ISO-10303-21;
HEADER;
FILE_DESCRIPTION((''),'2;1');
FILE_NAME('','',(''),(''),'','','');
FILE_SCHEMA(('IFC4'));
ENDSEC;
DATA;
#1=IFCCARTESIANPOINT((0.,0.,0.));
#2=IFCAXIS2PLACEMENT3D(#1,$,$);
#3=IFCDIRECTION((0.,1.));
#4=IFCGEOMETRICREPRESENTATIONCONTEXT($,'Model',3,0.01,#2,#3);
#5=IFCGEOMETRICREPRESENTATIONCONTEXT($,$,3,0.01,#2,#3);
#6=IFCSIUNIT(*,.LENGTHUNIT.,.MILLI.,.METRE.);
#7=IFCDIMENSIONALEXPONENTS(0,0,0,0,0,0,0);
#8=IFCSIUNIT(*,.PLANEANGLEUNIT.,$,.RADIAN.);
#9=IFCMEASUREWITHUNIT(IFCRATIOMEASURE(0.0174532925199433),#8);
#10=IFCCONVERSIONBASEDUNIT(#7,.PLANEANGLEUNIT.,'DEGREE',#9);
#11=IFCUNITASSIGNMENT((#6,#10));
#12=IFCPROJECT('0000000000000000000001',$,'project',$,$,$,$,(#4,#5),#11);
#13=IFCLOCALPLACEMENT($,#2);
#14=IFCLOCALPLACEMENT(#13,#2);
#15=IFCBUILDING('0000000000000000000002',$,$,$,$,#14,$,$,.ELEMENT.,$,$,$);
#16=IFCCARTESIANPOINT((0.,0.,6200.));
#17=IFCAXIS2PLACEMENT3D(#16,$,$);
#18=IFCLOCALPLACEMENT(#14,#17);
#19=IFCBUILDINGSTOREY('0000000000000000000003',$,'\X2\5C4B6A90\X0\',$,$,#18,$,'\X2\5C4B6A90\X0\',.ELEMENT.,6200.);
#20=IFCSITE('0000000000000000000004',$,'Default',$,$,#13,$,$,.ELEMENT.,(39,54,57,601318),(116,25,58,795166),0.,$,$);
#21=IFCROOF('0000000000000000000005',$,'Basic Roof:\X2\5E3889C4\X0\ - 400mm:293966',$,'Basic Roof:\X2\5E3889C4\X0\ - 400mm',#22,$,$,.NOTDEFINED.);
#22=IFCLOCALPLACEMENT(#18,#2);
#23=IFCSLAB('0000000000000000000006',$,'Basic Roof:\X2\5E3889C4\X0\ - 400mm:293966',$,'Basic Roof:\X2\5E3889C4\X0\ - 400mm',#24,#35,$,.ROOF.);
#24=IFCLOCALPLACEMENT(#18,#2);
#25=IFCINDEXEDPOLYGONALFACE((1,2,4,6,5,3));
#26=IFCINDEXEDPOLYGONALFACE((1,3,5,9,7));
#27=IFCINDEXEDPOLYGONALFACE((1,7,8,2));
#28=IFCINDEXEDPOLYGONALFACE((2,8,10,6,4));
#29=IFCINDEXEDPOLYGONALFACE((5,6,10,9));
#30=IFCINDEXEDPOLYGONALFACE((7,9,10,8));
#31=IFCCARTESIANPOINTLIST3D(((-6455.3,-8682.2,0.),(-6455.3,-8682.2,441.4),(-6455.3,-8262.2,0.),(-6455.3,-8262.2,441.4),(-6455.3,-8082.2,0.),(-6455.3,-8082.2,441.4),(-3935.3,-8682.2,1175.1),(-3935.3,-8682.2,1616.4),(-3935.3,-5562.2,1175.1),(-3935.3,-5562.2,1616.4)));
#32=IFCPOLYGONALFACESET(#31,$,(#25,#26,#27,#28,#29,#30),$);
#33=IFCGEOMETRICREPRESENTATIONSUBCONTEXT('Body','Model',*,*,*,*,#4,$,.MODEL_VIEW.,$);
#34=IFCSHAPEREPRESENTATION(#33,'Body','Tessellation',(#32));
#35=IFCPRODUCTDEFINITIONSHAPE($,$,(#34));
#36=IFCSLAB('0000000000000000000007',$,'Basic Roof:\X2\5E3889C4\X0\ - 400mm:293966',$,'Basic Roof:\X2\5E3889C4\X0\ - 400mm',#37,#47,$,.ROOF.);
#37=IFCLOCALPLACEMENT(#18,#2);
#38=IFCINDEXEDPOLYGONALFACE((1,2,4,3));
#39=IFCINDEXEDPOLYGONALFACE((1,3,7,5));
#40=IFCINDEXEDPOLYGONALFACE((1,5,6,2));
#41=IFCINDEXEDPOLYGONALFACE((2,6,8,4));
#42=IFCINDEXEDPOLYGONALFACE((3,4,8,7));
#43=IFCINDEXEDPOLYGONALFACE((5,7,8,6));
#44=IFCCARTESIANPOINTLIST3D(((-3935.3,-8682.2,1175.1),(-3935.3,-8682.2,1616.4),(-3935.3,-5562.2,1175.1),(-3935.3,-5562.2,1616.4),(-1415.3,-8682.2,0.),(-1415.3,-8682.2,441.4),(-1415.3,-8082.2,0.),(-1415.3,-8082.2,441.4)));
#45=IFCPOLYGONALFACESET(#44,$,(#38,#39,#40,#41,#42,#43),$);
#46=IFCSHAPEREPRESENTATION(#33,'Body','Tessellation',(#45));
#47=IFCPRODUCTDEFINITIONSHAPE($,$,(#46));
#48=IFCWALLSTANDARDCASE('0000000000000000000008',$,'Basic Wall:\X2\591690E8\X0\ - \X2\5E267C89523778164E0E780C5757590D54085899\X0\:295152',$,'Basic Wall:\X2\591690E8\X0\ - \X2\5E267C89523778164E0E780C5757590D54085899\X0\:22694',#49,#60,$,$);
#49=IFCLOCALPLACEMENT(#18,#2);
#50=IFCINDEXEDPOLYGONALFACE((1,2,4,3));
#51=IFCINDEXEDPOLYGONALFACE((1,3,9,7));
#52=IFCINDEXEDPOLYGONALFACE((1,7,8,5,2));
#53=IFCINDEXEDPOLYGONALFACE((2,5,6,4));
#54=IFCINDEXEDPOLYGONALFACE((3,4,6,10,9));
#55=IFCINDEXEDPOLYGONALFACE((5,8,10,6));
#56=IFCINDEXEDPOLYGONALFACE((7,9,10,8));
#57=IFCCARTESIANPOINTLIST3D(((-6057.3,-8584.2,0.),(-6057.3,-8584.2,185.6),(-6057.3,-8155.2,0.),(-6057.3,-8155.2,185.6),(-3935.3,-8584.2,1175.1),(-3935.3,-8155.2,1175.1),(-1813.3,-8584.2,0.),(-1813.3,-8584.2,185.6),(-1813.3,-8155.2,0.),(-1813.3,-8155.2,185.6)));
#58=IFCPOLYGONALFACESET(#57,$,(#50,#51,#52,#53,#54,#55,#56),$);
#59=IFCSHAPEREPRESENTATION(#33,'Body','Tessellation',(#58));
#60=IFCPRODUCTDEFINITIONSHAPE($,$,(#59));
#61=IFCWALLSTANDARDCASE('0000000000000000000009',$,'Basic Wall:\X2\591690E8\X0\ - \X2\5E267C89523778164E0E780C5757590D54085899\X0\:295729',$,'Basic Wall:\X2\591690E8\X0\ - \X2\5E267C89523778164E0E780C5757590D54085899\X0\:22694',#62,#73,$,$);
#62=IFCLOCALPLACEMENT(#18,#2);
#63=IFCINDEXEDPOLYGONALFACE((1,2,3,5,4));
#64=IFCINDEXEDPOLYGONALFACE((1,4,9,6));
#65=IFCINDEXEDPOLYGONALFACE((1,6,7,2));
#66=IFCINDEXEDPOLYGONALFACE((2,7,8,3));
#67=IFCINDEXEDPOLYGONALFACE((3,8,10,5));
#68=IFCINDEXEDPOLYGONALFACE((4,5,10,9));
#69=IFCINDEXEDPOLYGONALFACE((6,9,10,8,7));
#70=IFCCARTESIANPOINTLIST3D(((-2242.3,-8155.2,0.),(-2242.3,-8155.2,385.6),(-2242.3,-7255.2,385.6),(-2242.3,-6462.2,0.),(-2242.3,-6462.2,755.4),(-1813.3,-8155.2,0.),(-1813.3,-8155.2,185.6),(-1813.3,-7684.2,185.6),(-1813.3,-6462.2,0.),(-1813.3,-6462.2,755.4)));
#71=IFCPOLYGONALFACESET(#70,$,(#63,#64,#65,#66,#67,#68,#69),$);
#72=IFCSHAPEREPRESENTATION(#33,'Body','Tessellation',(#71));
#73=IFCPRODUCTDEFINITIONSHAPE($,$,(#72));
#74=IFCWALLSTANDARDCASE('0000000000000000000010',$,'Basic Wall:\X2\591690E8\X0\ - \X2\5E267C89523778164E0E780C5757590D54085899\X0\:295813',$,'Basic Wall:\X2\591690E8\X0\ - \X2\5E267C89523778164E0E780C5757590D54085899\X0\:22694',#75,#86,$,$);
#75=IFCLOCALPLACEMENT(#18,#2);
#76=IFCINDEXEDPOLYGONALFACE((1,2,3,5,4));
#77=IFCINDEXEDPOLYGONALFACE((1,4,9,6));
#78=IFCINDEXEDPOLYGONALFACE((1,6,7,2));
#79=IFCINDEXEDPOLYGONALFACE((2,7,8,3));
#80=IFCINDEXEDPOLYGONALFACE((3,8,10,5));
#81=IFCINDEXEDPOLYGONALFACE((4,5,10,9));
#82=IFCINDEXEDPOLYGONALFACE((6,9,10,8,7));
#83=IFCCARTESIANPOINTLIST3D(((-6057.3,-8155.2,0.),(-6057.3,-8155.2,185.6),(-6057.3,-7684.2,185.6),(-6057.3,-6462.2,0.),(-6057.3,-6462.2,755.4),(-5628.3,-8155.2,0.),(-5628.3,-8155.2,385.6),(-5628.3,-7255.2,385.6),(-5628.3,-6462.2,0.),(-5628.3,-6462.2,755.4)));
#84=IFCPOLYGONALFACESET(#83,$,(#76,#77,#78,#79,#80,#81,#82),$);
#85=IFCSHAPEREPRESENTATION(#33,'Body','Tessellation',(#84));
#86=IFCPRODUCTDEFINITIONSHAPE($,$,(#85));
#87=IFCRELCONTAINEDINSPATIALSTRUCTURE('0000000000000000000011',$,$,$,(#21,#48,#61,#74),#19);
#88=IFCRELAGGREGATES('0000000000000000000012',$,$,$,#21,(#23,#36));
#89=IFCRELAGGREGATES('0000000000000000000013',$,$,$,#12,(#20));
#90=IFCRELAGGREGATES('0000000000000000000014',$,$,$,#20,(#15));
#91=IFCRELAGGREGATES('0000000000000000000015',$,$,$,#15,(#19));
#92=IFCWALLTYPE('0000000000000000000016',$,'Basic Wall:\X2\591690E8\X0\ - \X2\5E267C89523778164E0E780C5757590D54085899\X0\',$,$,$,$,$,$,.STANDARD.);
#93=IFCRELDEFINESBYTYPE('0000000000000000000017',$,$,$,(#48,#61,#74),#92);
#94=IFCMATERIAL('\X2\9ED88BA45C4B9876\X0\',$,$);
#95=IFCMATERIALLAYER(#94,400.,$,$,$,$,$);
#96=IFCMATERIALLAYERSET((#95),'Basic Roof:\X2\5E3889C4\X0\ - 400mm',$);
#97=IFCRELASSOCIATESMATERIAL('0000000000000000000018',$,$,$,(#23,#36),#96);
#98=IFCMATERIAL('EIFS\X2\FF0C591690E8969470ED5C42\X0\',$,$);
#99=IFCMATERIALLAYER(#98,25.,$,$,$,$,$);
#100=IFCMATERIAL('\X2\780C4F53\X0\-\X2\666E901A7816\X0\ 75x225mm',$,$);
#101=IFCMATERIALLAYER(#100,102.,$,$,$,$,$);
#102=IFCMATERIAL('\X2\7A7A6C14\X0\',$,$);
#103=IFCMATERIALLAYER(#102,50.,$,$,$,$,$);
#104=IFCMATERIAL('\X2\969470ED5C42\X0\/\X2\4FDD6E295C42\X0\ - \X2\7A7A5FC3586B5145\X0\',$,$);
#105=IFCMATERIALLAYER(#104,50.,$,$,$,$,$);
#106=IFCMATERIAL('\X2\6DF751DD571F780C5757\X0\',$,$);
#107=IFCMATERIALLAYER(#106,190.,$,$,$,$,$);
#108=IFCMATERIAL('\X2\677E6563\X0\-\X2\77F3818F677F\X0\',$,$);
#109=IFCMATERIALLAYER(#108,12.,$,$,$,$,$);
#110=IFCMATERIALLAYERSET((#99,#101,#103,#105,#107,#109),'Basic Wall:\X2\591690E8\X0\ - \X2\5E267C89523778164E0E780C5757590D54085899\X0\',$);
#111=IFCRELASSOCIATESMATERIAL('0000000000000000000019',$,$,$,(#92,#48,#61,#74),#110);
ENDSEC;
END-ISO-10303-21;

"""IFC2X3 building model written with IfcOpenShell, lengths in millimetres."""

from ifc_helpers import new_model, entity, si_unit, converted_unit, direction, frame, frame_2d, origin, place, context, subcontext, project, spatial, polyline, rectangle, outline, extrude, clip, bounded_halfspace, material, layer, layer_set, layer_usage, type_object, element, aggregate, save


model = new_model("IFC2X3")

# Units and contexts
model_context = context("Model", 3, precision=0.01, world=origin(), true_north=direction((0.0, 1.0)))
context_of_model = context(None, 3, precision=0.01, world=origin(), true_north=direction((0.0, 1.0)))
body_context = subcontext(model_context, "Body", "Model", "MODEL_VIEW")
ifc_project = project(units=[si_unit("LENGTHUNIT", "METRE", prefix="MILLI"), converted_unit("PLANEANGLEUNIT", "DEGREE", entity("IfcRatioMeasure", 0.0174532925199433), si_unit("PLANEANGLEUNIT", "RADIAN"), dimensions=[0, 0, 0, 0, 0, 0, 0])], contexts=[model_context, context_of_model])

# Site, building, storey
site_placement = place(None, origin())
site = spatial("IfcSite", under=ifc_project, at=site_placement, Name="Default", CompositionType="ELEMENT", RefLatitude=(39, 54, 57, 601318), RefLongitude=(116, 25, 58, 795166), RefElevation=0.0)
building_placement = place(site_placement, origin())
building = spatial("IfcBuilding", under=site, at=building_placement, CompositionType="ELEMENT")
storey_placement = place(building_placement, frame((0.0, 0.0, 6200.0)))
storey = spatial("IfcBuildingStorey", under=building, at=storey_placement, Name="屋檐", LongName="屋檐", CompositionType="ELEMENT", Elevation=6200.0)

# Roof, slabs
roof_placement = place(storey_placement, frame((-9755.3, -8682.2, 0.0)))
roof = element("IfcRoof", 1, at=roof_placement, inside=storey, Name="Basic Roof:常规 - 400mm:293966", ObjectType="Basic Roof:常规 - 400mm", ShapeType="NOTDEFINED")
ifc_material_1 = material(Name="默认屋顶")
ifc_layer_1 = layer(ifc_material_1, 400.0)
ifc_layer_set_1 = layer_set([ifc_layer_1], Name="Basic Roof:常规 - 400mm")
slab_1_placement = place(roof_placement, origin())
slab_1 = element("IfcSlab", 2, at=slab_1_placement, material=ifc_layer_set_1, Name="Basic Roof:常规 - 400mm:293966", ObjectType="Basic Roof:常规 - 400mm", PredefinedType="ROOF", context=body_context, shape_type="SweptSolid", body=[
    extrude(outline(polyline([(-1390.3, -1560.0), (1390.3, -1560.0), (1390.3, 1560.0), (-1390.3, -960.0), (-1390.3, -1140.0), (-1390.3, -1560.0)])), frame((4560.0, 1560.0, 587.5), z_axis=(-0.422618, 0.0, 0.906308), x_axis=(0.906308, 0.0, 0.422618)), (0.422618, 0.0, 0.906308), 441.4),
])
slab_2_placement = place(roof_placement, origin())
slab_2 = element("IfcSlab", 3, at=slab_2_placement, material=ifc_layer_set_1, Name="Basic Roof:常规 - 400mm:293966", ObjectType="Basic Roof:常规 - 400mm", PredefinedType="ROOF", context=body_context, shape_type="SweptSolid", body=[
    extrude(outline(polyline([(1390.3, -960.0), (-1390.3, 1560.0), (-1390.3, -1560.0), (1390.3, -1560.0), (1390.3, -960.0)])), frame((7080.0, 1560.0, 587.5), z_axis=(0.422618, 0.0, 0.906308), x_axis=(0.906308, 0.0, -0.422618)), (-0.422618, 0.0, 0.906308), 441.4),
])
aggregate(roof, [slab_1, slab_2])

# Walls
ifc_material_2 = material(Name="EIFS，外部隔热层")
ifc_layer_2 = layer(ifc_material_2, 25.0)
ifc_material_3 = material(Name="砌体-普通砖 75x225mm")
ifc_layer_3 = layer(ifc_material_3, 102.0)
ifc_material_4 = material(Name="空气")
ifc_layer_4 = layer(ifc_material_4, 50.0)
ifc_material_5 = material(Name="隔热层/保温层 - 空心填充")
ifc_layer_5 = layer(ifc_material_5, 50.0)
ifc_material_6 = material(Name="混凝土砌块")
ifc_layer_6 = layer(ifc_material_6, 190.0)
ifc_material_7 = material(Name="松散-石膏板")
ifc_layer_7 = layer(ifc_material_7, 12.0)
ifc_layer_set_2 = layer_set([ifc_layer_2, ifc_layer_3, ifc_layer_4, ifc_layer_5, ifc_layer_6, ifc_layer_7], Name="Basic Wall:外部 - 带粉刷砖与砌块复合墙")
ifc_layer_usage_1 = layer_usage(ifc_layer_set_2, "AXIS2", "NEGATIVE", 214.5)
wall_type = type_object("IfcWallType", Name="Basic Wall:外部 - 带粉刷砖与砌块复合墙", PredefinedType="STANDARD", material=ifc_layer_set_2)
wall_1_placement = place(storey_placement, frame((-1813.3, -8369.7, 0.0), z_axis=(0.0, 0.0, 1.0), x_axis=(-1.0, 0.0, 0.0)))
element("IfcWallStandardCase", 4, at=wall_1_placement, inside=storey, type_object=wall_type, material=ifc_layer_usage_1, Name="Basic Wall:外部 - 带粉刷砖与砌块复合墙:295152", ObjectType="Basic Wall:外部 - 带粉刷砖与砌块复合墙:22694", context=body_context, shape_type="Clipping", body=[
    clip(clip(extrude(rectangle(XDim=4244.0, YDim=429.0, at=frame_2d((2122.0, 0.0), x_axis=(-1.0, 0.0))), origin(), (0.0, 0.0, 1.0), 1175.1), bounded_halfspace(frame((2122.0, -214.5, 1175.1), z_axis=(0.422618, 0.0, 0.906308), x_axis=(0.0, 1.0, 0.0)), False, frame((2122.0, -214.5, 1175.1)), polyline([(0.0, 0.0), (1693.0, 0.0), (2122.0, 0.0), (2122.0, 429.0), (0.0, 429.0), (0.0, 0.0)]))), bounded_halfspace(frame((0.0, -214.5, 185.6), z_axis=(-0.422618, 0.0, 0.906308), x_axis=(0.0, -1.0, 0.0)), False, frame((0.0, -214.5, 185.6)), polyline([(0.0, 0.0), (429.0, 0.0), (2122.0, 0.0), (2122.0, 429.0), (0.0, 429.0), (0.0, 0.0)]))),
])
ifc_layer_usage_2 = layer_usage(ifc_layer_set_2, "AXIS2", "NEGATIVE", 214.5)
wall_2_placement = place(storey_placement, frame((-2027.8, -6462.2, 0.0), z_axis=(0.0, 0.0, 1.0), x_axis=(0.0, -1.0, 0.0)))
element("IfcWallStandardCase", 5, at=wall_2_placement, inside=storey, type_object=wall_type, material=ifc_layer_usage_2, Name="Basic Wall:外部 - 带粉刷砖与砌块复合墙:295729", ObjectType="Basic Wall:外部 - 带粉刷砖与砌块复合墙:22694", context=body_context, shape_type="Clipping", body=[
    clip(clip(extrude(rectangle(XDim=1693.0, YDim=429.0, at=frame_2d((846.5, 0.0), x_axis=(-1.0, 0.0))), origin(), (0.0, 0.0, 1.0), 755.4), bounded_halfspace(frame((0.0, -214.5, 755.4), z_axis=(0.422618, 0.0, 0.906308), x_axis=(0.0, 1.0, 0.0)), False, frame((0.0, -214.5, 755.4)), polyline([(0.0, 0.0), (793.0, 0.0), (1222.0, 429.0), (0.0, 429.0), (0.0, 0.0)]))), bounded_halfspace(frame((793.0, -214.5, 385.6), z_axis=(0.0, 0.422618, 0.906308), x_axis=(-1.0, 0.0, 0.0)), False, frame((793.0, -214.5, 385.6)), polyline([(0.0, 0.0), (900.0, 0.0), (900.0, 429.0), (429.0, 429.0), (0.0, 0.0)]))),
])
ifc_layer_usage_3 = layer_usage(ifc_layer_set_2, "AXIS2", "NEGATIVE", 214.5)
wall_3_placement = place(storey_placement, frame((-5842.8, -8155.2, 0.0), z_axis=(0.0, 0.0, 1.0), x_axis=(0.0, 1.0, 0.0)))
element("IfcWallStandardCase", 6, at=wall_3_placement, inside=storey, type_object=wall_type, material=ifc_layer_usage_3, Name="Basic Wall:外部 - 带粉刷砖与砌块复合墙:295813", ObjectType="Basic Wall:外部 - 带粉刷砖与砌块复合墙:22694", context=body_context, shape_type="Clipping", body=[
    clip(clip(extrude(rectangle(XDim=1693.0, YDim=429.0, at=frame_2d((846.5, 0.0), x_axis=(-1.0, 0.0))), origin(), (0.0, 0.0, 1.0), 755.4), bounded_halfspace(frame((0.0, -214.5, 385.6), z_axis=(0.0, 0.422618, 0.906308), x_axis=(-1.0, 0.0, 0.0)), False, frame((0.0, -214.5, 385.6)), polyline([(0.0, 0.0), (900.0, 0.0), (471.0, 429.0), (0.0, 429.0), (0.0, 0.0)]))), bounded_halfspace(frame((900.0, -214.5, 385.6), z_axis=(-0.422618, 0.0, 0.906308), x_axis=(0.0, -1.0, 0.0)), False, frame((900.0, -214.5, 385.6)), polyline([(0.0, 0.0), (793.0, 0.0), (793.0, 429.0), (-429.0, 429.0), (0.0, 0.0)]))),
])

save(model, "model.ifc")
